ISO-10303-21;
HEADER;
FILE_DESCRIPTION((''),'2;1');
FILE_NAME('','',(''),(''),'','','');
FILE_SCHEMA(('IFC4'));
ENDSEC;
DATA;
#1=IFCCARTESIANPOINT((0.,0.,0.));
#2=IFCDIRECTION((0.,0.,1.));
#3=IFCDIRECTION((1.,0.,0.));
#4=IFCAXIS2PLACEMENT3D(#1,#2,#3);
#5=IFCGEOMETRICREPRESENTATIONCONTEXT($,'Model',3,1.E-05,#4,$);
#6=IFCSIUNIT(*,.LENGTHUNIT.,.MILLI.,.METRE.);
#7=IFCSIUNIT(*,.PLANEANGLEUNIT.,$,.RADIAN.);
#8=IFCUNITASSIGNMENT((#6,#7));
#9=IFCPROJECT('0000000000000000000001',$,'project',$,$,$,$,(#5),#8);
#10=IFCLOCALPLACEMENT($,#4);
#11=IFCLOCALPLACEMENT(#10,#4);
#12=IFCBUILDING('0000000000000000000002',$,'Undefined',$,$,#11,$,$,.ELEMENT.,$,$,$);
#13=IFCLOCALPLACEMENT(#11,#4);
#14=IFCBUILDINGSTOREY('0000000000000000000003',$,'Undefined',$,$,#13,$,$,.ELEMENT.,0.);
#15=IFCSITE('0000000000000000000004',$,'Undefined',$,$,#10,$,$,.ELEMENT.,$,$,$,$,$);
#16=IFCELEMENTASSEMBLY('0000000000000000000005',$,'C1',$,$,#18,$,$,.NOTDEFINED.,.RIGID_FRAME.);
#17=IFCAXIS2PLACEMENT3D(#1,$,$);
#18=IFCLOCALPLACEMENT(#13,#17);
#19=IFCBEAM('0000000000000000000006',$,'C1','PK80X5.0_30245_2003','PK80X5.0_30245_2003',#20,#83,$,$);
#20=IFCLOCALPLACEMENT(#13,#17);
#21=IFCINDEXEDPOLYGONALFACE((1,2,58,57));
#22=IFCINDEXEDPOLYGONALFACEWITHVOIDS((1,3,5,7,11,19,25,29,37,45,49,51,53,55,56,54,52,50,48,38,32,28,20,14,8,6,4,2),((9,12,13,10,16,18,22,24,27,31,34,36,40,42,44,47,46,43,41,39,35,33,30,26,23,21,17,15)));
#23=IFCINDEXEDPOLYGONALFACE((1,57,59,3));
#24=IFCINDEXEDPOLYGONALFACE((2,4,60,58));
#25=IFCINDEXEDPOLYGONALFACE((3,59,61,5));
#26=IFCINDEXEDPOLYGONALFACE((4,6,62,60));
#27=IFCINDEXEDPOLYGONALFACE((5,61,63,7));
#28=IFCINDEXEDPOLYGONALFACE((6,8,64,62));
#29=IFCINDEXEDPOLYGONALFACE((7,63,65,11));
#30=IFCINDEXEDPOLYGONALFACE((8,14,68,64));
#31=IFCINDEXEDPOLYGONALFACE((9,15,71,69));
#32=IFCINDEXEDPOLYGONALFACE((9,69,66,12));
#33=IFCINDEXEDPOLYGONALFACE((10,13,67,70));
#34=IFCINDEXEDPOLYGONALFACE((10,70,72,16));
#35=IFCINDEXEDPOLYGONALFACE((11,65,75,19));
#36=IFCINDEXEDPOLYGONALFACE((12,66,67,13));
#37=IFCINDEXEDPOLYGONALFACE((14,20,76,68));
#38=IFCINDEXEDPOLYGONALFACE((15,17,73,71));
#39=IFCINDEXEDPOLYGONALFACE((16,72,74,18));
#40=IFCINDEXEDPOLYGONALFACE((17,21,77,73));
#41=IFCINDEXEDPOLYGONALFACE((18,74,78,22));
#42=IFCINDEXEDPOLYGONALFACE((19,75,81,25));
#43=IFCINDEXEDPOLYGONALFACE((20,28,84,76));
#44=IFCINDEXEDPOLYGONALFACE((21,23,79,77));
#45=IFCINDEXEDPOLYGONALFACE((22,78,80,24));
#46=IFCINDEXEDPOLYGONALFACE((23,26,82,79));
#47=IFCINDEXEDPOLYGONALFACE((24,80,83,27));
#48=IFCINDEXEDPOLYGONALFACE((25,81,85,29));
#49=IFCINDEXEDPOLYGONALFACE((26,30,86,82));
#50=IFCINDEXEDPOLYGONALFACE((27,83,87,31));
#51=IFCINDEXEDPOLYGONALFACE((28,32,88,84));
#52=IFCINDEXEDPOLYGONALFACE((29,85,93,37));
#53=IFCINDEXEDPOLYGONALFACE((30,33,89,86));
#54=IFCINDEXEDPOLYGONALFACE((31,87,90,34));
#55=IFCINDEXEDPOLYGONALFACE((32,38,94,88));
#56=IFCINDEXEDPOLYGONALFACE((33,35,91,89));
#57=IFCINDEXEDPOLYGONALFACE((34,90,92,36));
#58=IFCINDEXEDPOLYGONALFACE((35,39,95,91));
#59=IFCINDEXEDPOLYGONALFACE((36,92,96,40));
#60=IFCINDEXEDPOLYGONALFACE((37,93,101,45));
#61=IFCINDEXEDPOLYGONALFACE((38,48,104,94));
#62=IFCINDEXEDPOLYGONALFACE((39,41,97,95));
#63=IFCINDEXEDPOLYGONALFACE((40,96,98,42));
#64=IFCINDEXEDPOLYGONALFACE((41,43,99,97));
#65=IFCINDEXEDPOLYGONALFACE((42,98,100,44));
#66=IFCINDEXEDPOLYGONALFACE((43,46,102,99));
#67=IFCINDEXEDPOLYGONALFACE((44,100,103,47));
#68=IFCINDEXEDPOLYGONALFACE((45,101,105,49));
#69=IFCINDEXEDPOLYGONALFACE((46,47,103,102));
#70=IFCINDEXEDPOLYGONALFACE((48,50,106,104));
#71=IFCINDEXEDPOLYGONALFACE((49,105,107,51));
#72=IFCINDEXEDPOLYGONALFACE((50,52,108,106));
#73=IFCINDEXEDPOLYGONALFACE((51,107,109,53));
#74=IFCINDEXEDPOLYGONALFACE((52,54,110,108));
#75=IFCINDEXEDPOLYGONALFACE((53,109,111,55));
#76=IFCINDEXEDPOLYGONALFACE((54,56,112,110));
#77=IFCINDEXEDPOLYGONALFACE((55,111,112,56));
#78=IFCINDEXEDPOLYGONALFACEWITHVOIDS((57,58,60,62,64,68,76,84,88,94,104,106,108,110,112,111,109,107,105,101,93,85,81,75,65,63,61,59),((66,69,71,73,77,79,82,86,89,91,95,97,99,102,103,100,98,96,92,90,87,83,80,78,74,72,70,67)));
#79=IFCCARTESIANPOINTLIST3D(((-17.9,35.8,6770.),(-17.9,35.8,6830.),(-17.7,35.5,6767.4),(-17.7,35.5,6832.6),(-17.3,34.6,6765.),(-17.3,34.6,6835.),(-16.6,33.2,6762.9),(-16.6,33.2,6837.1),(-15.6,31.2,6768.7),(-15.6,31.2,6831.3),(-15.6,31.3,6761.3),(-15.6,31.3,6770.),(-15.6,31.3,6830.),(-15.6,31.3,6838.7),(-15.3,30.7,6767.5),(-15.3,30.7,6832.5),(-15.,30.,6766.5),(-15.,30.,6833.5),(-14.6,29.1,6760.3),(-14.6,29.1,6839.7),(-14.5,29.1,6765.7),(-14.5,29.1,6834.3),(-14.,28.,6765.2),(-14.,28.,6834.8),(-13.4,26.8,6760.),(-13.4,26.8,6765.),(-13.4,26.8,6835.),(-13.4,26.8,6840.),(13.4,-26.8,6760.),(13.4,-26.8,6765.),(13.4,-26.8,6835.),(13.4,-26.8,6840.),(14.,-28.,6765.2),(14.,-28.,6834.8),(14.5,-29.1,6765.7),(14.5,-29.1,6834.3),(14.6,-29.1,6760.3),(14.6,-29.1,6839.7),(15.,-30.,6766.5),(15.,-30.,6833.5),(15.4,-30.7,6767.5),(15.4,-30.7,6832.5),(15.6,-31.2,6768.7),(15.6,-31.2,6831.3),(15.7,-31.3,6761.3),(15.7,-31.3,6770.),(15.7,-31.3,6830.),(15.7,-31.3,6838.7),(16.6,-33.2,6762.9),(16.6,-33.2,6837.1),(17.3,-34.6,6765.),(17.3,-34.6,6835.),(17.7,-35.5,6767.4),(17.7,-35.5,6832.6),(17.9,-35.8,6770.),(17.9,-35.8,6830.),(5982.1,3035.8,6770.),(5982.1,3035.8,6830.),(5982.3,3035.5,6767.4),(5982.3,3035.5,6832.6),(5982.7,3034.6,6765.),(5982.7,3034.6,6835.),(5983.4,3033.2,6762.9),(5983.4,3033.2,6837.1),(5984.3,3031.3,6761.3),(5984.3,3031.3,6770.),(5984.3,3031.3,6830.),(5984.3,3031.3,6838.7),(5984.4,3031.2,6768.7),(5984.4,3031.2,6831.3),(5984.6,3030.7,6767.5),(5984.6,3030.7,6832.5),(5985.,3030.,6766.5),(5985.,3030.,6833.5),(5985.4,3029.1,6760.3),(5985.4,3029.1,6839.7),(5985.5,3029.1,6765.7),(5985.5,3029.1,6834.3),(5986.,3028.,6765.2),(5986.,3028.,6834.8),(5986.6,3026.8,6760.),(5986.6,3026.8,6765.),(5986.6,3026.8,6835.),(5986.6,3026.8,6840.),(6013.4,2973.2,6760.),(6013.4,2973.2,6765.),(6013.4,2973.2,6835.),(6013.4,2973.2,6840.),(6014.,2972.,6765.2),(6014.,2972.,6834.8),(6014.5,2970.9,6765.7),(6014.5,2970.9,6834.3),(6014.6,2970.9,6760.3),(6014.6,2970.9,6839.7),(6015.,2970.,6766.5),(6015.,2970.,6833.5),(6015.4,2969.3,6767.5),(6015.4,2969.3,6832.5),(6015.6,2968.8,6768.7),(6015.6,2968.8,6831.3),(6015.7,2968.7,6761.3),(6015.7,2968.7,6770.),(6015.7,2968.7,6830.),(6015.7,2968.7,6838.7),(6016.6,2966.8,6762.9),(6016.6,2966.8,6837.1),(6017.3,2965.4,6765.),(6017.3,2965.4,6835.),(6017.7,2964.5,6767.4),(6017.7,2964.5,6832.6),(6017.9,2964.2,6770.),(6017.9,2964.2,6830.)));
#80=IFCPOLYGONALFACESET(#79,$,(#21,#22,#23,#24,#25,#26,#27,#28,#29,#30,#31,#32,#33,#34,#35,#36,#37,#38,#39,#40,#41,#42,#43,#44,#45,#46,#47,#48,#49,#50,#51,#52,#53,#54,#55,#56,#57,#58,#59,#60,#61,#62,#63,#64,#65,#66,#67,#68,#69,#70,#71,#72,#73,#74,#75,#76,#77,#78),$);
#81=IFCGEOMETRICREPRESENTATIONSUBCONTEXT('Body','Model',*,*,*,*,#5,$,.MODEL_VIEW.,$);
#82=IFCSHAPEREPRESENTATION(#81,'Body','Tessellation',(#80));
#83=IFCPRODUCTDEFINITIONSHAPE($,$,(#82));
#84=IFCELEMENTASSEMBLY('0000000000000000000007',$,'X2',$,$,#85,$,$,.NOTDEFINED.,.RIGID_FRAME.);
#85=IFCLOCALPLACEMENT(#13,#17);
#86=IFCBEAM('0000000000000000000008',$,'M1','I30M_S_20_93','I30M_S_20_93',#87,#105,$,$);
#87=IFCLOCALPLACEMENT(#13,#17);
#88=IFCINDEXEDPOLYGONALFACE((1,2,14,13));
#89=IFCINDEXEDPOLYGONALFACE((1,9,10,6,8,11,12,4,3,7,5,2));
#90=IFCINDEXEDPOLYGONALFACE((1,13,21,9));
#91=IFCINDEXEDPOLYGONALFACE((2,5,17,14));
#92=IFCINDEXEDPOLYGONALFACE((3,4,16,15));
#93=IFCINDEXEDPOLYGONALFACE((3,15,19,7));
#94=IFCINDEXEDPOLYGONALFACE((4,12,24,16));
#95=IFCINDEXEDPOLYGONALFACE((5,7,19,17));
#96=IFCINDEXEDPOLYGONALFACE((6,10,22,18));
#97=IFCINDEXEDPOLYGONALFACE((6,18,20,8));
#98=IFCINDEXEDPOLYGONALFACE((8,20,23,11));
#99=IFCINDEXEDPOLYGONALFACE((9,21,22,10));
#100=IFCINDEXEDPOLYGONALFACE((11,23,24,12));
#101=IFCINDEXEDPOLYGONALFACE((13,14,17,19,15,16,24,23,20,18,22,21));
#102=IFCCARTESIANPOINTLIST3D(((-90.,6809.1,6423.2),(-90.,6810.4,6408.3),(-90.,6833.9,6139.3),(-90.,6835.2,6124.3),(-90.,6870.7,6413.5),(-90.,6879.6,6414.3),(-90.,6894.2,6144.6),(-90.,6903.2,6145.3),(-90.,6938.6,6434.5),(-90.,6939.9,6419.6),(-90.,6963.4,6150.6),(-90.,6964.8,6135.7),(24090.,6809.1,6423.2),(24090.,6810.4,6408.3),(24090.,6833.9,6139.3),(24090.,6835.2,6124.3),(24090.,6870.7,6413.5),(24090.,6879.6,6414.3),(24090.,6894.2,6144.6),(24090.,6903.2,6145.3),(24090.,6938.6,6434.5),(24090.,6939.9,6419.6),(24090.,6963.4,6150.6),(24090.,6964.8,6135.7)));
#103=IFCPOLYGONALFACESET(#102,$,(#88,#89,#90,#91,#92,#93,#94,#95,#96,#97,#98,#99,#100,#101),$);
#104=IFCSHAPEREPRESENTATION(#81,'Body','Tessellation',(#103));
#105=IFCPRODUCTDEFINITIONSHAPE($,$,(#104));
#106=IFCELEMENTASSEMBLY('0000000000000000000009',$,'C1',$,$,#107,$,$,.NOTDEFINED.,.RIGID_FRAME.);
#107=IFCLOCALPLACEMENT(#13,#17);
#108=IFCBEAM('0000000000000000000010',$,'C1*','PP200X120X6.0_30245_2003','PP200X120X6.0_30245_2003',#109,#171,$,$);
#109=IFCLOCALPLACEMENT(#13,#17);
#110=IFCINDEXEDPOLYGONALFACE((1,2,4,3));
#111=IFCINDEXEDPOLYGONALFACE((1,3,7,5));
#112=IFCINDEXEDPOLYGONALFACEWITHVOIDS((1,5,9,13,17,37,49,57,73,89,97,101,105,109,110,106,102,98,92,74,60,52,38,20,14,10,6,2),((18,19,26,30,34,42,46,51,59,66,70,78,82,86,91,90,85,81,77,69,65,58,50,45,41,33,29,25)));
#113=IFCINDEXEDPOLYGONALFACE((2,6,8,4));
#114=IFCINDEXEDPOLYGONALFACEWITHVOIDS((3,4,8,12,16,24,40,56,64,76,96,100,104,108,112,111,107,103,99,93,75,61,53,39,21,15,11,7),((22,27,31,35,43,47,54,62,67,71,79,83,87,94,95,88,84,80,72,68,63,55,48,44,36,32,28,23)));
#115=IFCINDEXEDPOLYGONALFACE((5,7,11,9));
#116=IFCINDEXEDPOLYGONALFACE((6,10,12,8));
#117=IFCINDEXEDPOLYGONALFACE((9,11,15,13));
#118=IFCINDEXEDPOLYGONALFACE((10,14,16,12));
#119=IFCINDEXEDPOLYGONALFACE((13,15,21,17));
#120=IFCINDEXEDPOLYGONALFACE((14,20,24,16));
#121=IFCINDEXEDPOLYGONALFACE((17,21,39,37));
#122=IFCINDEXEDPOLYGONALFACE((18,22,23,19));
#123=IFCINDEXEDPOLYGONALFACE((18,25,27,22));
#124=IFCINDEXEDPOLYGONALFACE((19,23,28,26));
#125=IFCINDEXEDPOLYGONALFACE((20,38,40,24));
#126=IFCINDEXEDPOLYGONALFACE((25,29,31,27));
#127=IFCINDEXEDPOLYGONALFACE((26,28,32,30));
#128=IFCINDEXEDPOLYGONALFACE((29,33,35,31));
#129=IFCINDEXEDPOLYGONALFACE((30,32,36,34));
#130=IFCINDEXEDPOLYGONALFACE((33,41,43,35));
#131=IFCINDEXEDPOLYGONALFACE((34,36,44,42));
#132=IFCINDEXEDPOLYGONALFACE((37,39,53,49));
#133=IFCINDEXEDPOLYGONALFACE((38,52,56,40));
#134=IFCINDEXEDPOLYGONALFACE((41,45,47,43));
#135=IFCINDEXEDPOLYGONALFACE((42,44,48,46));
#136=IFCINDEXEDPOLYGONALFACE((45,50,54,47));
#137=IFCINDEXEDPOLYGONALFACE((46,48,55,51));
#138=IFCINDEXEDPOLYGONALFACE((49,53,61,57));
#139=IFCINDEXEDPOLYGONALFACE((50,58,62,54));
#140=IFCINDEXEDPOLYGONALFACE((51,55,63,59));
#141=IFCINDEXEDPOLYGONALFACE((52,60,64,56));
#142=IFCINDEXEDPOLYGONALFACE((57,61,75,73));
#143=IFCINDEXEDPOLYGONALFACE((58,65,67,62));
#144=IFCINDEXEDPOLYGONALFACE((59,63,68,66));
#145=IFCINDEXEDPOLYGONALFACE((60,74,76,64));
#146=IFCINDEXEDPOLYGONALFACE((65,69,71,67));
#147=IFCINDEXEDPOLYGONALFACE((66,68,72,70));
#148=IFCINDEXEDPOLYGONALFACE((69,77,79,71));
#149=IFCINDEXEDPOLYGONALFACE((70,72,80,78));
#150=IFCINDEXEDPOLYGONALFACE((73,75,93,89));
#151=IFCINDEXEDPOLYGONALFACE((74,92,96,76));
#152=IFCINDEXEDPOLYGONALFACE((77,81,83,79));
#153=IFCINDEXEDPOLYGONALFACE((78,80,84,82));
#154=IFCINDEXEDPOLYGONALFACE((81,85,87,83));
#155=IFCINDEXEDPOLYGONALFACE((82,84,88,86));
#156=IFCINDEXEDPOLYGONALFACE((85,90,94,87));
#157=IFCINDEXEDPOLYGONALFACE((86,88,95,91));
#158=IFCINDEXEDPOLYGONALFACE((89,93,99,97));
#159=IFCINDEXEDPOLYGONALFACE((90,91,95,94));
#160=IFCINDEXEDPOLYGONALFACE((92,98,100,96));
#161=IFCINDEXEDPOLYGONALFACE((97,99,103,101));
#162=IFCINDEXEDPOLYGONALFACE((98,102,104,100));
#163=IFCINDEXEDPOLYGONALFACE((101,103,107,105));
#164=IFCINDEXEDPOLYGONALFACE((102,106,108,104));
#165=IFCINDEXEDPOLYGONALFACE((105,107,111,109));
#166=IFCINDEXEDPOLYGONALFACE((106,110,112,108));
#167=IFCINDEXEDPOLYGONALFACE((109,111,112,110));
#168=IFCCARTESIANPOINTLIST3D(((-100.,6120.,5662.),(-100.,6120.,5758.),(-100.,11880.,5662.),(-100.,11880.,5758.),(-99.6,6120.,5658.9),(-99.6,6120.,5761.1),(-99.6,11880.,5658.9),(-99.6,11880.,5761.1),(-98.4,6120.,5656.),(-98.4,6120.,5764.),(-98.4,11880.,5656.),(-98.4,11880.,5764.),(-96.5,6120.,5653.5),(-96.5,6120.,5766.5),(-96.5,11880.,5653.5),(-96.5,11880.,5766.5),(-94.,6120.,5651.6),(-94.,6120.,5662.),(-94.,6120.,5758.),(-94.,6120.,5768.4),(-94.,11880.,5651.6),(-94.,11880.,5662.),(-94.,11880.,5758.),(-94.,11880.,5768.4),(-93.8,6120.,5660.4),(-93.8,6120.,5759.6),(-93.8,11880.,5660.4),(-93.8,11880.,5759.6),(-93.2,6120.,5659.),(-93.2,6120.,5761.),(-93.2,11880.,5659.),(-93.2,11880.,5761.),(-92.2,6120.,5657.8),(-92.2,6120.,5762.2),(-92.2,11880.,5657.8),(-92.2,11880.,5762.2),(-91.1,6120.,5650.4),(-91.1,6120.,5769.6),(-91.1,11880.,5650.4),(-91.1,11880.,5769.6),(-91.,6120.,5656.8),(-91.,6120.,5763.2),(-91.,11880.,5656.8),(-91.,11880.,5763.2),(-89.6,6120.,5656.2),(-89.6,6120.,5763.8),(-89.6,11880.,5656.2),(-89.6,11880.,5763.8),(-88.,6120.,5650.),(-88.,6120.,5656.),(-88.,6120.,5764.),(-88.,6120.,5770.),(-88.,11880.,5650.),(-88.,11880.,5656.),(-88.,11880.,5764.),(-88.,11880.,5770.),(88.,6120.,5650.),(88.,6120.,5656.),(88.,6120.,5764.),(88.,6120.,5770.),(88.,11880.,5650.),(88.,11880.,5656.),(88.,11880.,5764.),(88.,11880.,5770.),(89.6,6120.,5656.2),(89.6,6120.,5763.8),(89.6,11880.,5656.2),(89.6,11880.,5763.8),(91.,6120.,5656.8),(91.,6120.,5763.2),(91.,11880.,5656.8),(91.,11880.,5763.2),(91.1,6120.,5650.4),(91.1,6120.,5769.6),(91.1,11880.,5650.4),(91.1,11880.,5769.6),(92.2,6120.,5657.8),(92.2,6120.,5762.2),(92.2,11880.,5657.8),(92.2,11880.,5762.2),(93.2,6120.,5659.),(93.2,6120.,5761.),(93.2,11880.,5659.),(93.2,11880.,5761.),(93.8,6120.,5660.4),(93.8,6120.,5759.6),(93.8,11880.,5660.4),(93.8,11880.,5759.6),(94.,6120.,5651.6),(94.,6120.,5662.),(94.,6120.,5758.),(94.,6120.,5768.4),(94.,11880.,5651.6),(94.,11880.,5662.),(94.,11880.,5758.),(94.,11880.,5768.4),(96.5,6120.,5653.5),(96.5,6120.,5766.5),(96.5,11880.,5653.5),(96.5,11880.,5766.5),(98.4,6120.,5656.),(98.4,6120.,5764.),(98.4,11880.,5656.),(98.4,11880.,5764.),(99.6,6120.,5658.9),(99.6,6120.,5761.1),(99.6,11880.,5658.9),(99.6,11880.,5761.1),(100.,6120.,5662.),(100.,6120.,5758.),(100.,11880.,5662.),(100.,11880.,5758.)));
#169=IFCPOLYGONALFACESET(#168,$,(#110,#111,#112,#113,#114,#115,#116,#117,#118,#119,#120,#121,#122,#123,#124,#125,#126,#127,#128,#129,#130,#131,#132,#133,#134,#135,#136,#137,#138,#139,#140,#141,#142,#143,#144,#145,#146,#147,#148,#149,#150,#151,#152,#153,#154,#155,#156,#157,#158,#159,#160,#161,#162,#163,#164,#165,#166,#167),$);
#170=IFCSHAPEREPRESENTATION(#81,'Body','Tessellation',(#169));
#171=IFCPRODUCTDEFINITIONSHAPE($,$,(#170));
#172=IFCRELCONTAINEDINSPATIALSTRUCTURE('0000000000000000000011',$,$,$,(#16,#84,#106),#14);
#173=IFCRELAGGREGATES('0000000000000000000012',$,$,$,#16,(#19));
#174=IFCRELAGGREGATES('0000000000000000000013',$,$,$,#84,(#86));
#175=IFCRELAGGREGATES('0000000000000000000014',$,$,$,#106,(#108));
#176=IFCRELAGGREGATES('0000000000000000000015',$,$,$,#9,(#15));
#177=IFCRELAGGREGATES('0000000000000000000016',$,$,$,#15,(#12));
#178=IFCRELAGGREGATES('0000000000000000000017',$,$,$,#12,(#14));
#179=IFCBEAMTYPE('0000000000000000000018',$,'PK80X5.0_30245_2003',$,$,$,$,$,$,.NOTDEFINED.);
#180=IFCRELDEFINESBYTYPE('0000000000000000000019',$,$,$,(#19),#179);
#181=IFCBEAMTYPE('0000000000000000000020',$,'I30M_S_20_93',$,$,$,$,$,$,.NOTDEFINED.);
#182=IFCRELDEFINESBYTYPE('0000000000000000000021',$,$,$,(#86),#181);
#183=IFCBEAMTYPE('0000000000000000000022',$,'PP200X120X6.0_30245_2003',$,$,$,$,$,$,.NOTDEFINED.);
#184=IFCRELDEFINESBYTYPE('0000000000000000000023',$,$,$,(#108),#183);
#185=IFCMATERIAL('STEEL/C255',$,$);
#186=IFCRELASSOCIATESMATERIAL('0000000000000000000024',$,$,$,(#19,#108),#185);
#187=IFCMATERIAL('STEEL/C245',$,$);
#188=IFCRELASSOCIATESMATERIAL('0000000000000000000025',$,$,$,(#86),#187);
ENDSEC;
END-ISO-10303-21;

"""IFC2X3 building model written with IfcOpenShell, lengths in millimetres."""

from ifc_helpers import new_model, si_unit, frame, origin_with_axes, origin_2d_with_axis, place, context, subcontext, project, spatial, hollow_rectangle, i_section, extrude, material, type_object, element, aggregate, save


model = new_model("IFC2X3")

# Units and contexts
model_context = context("Model", 3, precision=1e-05, world=origin_with_axes())
body_context = subcontext(model_context, "Body", "Model", "MODEL_VIEW")
ifc_project = project(units=[si_unit("LENGTHUNIT", "METRE", prefix="MILLI"), si_unit("PLANEANGLEUNIT", "RADIAN")], contexts=[model_context])

# Site, building, storey
site_placement = place(None, origin_with_axes())
site = spatial("IfcSite", under=ifc_project, at=site_placement, Name="Undefined", CompositionType="ELEMENT")
building_placement = place(site_placement, origin_with_axes())
building = spatial("IfcBuilding", under=site, at=building_placement, Name="Undefined", CompositionType="ELEMENT")
storey_placement = place(building_placement, origin_with_axes())
storey = spatial("IfcBuildingStorey", under=building, at=storey_placement, Name="Undefined", CompositionType="ELEMENT", Elevation=0.0)

# Shared definitions
ifc_material_1 = material(Name="STEEL/C245")

# Element assemblies, beams
ifc_material_2 = material(Name="STEEL/C255")
beam_type_1 = type_object("IfcBeamType", Name="PK80X5.0_30245_2003", PredefinedType="NOTDEFINED")
assembly_1_placement = place(storey_placement, origin_with_axes())
assembly_1 = element("IfcElementAssembly", 1, at=assembly_1_placement, inside=storey, Name="C1", AssemblyPlace="NOTDEFINED", PredefinedType="RIGID_FRAME")
beam_1_placement = place(assembly_1_placement, frame((0.0, 0.0, 6800.0), z_axis=(0.0, 0.0, -1.0), x_axis=(0.894427, 0.447214, 0.0)))
beam_1 = element("IfcBeam", 2, at=beam_1_placement, type_object=beam_type_1, material=ifc_material_2, Name="C1", Description="PK80X5.0_30245_2003", ObjectType="PK80X5.0_30245_2003", context=body_context, shape_type="SweptSolid", body=[
    extrude(hollow_rectangle(XDim=80.0, YDim=80.0, WallThickness=5.0, InnerFilletRadius=5.0, OuterFilletRadius=10.0, at=origin_2d_with_axis()), frame((6708.2, 0.0, 0.0), z_axis=(-1.0, 0.0, 0.0), x_axis=(0.0, -1.0, 0.0)), (0.0, 0.0, 1.0), 6708.2),
])
aggregate(assembly_1, [beam_1])
assembly_2_placement = place(storey_placement, origin_with_axes())
assembly_2 = element("IfcElementAssembly", 3, at=assembly_2_placement, inside=storey, Name="X2", AssemblyPlace="NOTDEFINED", PredefinedType="RIGID_FRAME")
beam_type_2 = type_object("IfcBeamType", Name="I30M_S_20_93", PredefinedType="NOTDEFINED")
beam_2_placement = place(assembly_2_placement, frame((-90.0, 6886.9, 6279.4), z_axis=(0.0, -0.087156, 0.996195), x_axis=(1.0, 0.0, 0.0)))
beam_2 = element("IfcBeam", 4, at=beam_2_placement, type_object=beam_type_2, material=ifc_material_1, Name="M1", Description="I30M_S_20_93", ObjectType="I30M_S_20_93", context=body_context, shape_type="SweptSolid", body=[
    extrude(i_section(OverallWidth=130.0, OverallDepth=300.0, WebThickness=9.0, FlangeThickness=15.0, at=origin_2d_with_axis()), frame((24180.0, 0.0, 0.0), z_axis=(-1.0, 0.0, 0.0), x_axis=(0.0, -1.0, 0.0)), (0.0, 0.0, 1.0), 24180.0),
])
aggregate(assembly_2, [beam_2])
assembly_3_placement = place(storey_placement, origin_with_axes())
assembly_3 = element("IfcElementAssembly", 5, at=assembly_3_placement, inside=storey, Name="C1", AssemblyPlace="NOTDEFINED", PredefinedType="RIGID_FRAME")
beam_type_3 = type_object("IfcBeamType", Name="PP200X120X6.0_30245_2003", PredefinedType="NOTDEFINED")
beam_3_placement = place(assembly_3_placement, frame((0.0, 6120.0, 5710.0), z_axis=(-1.0, 0.0, 0.0), x_axis=(0.0, 1.0, 0.0)))
beam_3 = element("IfcBeam", 6, at=beam_3_placement, type_object=beam_type_3, material=ifc_material_2, Name="C1*", Description="PP200X120X6.0_30245_2003", ObjectType="PP200X120X6.0_30245_2003", context=body_context, shape_type="SweptSolid", body=[
    extrude(hollow_rectangle(XDim=120.0, YDim=200.0, WallThickness=6.0, InnerFilletRadius=6.0, OuterFilletRadius=12.0, at=origin_2d_with_axis()), frame((5760.0, 0.0, 0.0), z_axis=(-1.0, 0.0, 0.0), x_axis=(0.0, -1.0, 0.0)), (0.0, 0.0, 1.0), 5760.0),
])
aggregate(assembly_3, [beam_3])

save(model, "model.ifc")
